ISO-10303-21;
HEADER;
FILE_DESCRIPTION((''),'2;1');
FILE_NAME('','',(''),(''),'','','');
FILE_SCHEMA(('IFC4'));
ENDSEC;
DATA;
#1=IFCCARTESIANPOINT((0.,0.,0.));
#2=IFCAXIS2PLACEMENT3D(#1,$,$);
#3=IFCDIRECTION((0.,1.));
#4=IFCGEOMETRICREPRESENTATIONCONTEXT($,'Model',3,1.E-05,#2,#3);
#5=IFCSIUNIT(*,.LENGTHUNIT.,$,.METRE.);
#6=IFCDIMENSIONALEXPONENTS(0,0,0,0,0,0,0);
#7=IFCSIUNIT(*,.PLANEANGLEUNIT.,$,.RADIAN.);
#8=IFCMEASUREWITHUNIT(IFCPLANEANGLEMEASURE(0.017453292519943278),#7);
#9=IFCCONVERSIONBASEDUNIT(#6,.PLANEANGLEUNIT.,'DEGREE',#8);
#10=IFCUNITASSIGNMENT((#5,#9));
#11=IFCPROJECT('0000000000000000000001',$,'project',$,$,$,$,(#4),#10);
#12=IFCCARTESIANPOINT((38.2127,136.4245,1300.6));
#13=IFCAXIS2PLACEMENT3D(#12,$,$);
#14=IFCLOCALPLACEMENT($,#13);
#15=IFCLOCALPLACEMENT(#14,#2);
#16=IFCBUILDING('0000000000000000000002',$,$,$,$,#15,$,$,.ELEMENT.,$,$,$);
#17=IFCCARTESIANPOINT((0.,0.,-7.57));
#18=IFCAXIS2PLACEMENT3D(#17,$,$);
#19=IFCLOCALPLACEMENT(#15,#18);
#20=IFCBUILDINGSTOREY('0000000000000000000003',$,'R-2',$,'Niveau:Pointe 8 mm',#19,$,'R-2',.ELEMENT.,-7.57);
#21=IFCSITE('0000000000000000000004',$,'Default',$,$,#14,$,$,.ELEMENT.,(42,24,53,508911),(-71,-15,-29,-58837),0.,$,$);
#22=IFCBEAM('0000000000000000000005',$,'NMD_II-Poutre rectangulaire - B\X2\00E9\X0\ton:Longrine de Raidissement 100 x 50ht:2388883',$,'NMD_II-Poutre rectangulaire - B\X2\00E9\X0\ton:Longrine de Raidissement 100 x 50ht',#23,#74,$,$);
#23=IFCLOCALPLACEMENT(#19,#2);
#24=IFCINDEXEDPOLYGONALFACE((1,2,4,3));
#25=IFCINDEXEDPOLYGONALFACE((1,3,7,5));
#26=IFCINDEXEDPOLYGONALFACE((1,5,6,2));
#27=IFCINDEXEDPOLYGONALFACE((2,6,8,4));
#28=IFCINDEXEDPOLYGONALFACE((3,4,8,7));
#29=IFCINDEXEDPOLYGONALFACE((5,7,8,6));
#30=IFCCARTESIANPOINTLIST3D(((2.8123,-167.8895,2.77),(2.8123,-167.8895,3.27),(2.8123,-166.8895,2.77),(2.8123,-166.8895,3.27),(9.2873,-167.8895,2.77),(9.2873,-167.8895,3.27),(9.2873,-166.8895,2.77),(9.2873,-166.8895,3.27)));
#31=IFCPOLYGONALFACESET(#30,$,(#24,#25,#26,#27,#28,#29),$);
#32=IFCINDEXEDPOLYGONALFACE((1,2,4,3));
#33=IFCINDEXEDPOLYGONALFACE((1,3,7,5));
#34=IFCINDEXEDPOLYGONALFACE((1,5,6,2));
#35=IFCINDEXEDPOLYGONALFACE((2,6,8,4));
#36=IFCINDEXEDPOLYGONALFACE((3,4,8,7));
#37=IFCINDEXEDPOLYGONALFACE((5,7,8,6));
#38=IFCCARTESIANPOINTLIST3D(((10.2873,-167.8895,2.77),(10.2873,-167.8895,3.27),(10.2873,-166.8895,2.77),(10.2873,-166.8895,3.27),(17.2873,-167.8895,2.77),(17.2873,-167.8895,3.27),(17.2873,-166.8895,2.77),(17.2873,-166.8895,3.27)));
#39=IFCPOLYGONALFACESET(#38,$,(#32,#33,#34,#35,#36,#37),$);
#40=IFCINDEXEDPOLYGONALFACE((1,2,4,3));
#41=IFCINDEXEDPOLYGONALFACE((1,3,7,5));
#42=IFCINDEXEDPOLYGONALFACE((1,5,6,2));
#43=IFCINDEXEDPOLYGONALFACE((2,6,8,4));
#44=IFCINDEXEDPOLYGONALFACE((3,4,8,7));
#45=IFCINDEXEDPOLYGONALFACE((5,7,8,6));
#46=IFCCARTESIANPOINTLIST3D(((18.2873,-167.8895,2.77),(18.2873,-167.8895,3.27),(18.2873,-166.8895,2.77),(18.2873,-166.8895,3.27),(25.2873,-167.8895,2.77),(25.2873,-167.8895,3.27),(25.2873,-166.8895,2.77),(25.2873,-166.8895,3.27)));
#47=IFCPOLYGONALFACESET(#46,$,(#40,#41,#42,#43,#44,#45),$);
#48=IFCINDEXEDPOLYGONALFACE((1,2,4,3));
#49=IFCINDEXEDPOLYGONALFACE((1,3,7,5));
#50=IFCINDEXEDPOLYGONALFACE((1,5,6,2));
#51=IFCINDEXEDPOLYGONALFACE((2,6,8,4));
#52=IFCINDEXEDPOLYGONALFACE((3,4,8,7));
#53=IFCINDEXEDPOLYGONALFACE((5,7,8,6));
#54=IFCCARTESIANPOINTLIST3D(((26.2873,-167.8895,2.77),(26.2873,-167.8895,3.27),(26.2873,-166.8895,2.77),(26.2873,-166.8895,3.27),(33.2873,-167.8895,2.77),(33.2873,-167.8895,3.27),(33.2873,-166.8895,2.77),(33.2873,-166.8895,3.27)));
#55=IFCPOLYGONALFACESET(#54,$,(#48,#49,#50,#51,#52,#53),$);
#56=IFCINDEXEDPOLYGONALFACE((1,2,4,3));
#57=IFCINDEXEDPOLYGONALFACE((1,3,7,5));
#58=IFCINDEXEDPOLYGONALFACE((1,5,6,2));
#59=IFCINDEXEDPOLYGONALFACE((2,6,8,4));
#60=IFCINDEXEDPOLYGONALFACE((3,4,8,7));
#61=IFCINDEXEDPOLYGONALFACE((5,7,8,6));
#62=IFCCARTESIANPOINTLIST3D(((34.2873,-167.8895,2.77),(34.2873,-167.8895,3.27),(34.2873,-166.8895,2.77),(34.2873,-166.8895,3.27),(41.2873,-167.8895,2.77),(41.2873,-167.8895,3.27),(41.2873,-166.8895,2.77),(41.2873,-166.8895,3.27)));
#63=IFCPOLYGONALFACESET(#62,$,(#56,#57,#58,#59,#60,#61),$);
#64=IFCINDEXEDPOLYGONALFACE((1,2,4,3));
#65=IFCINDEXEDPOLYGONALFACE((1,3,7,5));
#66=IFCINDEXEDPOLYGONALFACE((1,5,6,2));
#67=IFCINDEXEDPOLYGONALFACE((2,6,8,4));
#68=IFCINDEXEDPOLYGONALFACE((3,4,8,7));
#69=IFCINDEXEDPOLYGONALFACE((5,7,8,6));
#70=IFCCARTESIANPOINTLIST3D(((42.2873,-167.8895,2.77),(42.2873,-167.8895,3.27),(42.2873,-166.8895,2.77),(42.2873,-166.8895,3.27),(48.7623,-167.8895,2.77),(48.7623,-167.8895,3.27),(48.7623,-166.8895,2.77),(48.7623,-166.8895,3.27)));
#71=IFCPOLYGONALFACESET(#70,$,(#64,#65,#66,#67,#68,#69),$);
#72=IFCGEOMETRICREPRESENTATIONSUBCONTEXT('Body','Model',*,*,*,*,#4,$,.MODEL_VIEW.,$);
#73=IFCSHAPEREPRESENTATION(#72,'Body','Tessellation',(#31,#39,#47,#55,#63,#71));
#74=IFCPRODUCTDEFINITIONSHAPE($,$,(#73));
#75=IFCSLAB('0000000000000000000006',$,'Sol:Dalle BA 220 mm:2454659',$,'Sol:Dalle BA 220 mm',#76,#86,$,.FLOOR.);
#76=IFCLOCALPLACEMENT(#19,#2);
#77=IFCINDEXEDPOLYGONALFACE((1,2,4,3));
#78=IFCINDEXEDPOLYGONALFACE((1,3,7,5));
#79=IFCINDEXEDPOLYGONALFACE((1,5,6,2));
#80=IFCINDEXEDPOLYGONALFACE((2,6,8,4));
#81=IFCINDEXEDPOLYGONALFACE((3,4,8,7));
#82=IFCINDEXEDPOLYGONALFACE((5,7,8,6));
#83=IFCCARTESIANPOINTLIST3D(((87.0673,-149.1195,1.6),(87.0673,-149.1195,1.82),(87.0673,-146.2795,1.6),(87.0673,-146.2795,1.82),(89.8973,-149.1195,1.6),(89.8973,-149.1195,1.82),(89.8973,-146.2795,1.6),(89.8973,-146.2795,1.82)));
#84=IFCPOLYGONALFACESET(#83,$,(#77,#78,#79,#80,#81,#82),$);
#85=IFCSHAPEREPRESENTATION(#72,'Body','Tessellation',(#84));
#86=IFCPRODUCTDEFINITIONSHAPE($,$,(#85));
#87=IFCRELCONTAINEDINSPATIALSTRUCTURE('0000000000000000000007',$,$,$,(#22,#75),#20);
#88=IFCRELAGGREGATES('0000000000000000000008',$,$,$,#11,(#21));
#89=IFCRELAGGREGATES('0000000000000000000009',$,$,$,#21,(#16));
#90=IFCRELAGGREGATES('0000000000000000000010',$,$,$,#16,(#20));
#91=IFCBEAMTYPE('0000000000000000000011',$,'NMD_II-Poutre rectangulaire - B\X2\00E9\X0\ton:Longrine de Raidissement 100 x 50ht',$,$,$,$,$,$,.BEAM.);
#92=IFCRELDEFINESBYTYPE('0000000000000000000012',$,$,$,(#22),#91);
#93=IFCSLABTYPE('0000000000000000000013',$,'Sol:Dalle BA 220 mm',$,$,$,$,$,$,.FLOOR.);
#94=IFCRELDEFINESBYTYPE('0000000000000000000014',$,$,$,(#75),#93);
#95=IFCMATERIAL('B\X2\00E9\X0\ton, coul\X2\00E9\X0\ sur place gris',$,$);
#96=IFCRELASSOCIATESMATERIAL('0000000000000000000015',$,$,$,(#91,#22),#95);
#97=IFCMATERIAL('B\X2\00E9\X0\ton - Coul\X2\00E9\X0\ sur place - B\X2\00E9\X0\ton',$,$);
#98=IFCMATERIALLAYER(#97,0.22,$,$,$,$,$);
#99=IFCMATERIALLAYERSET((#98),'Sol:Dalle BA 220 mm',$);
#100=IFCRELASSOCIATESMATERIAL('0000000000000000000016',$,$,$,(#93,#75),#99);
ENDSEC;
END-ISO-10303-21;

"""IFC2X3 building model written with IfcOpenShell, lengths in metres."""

from ifc_helpers import new_model, entity, si_unit, converted_unit, direction, frame, frame_2d, origin, place, context, subcontext, project, spatial, rectangle, extrude, source, transform, mapped, material, layer, layer_set, layer_usage, type_object, type_shapes, element, save


model = new_model("IFC2X3")

# Units and contexts
model_context = context("Model", 3, precision=1e-05, world=origin(), true_north=direction((0.0, 1.0)))
body_context = subcontext(model_context, "Body", "Model", "MODEL_VIEW")
ifc_project = project(units=[si_unit("LENGTHUNIT", "METRE"), converted_unit("PLANEANGLEUNIT", "DEGREE", entity("IfcPlaneAngleMeasure", 0.017453292519943278), si_unit("PLANEANGLEUNIT", "RADIAN"), dimensions=[0, 0, 0, 0, 0, 0, 0])], contexts=[model_context])

# Site, building, storey
site_placement = place(None, frame((38.2127, 136.4245, 1300.6)))
site = spatial("IfcSite", under=ifc_project, at=site_placement, Name="Default", CompositionType="ELEMENT", RefLatitude=(42, 24, 53, 508911), RefLongitude=(-71, -15, -29, -58837), RefElevation=0.0)
building_placement = place(site_placement, origin())
building = spatial("IfcBuilding", under=site, at=building_placement, CompositionType="ELEMENT")
storey_placement = place(building_placement, frame((0.0, 0.0, -7.57)))
storey = spatial("IfcBuildingStorey", under=building, at=storey_placement, Name="R-2", ObjectType="Niveau:Pointe 8 mm", LongName="R-2", CompositionType="ELEMENT", Elevation=-7.57)

# Beam
ifc_material_1 = material(Name="Béton, coulé sur place gris")
beam_type_1 = type_object("IfcBeamType", Name="NMD_II-Poutre rectangulaire - Béton:Longrine de Raidissement 100 x 50ht", PredefinedType="BEAM", material=ifc_material_1)
shared_shape_1 = source(origin(), body_context, "Body", "SweptSolid", [
    extrude(rectangle(XDim=0.5, YDim=1.0, at=frame_2d((0.0, 0.0), x_axis=(1.0, 0.0))), frame((9.2873, -167.3895, -4.55), z_axis=(-1.0, 0.0, 0.0), x_axis=(0.0, 0.0, -1.0)), (0.0, 0.0, 1.0), 6.475),
    extrude(rectangle(XDim=0.5, YDim=1.0, at=frame_2d((0.0, 0.0), x_axis=(1.0, 0.0))), frame((17.2873, -167.3895, -4.55), z_axis=(-1.0, 0.0, 0.0), x_axis=(0.0, 0.0, -1.0)), (0.0, 0.0, 1.0), 7.0),
    extrude(rectangle(XDim=0.5, YDim=1.0, at=frame_2d((0.0, 0.0), x_axis=(1.0, 0.0))), frame((25.2873, -167.3895, -4.55), z_axis=(-1.0, 0.0, 0.0), x_axis=(0.0, 0.0, -1.0)), (0.0, 0.0, 1.0), 7.0),
    extrude(rectangle(XDim=0.5, YDim=1.0, at=frame_2d((0.0, 0.0), x_axis=(1.0, 0.0))), frame((33.2873, -167.3895, -4.55), z_axis=(-1.0, 0.0, 0.0), x_axis=(0.0, 0.0, -1.0)), (0.0, 0.0, 1.0), 7.0),
    extrude(rectangle(XDim=0.5, YDim=1.0, at=frame_2d((0.0, 0.0), x_axis=(1.0, 0.0))), frame((41.2873, -167.3895, -4.55), z_axis=(-1.0, 0.0, 0.0), x_axis=(0.0, 0.0, -1.0)), (0.0, 0.0, 1.0), 7.0),
    extrude(rectangle(XDim=0.5, YDim=1.0, at=frame_2d((0.0, 0.0), x_axis=(1.0, 0.0))), frame((48.7623, -167.3895, -4.55), z_axis=(-1.0, 0.0, 0.0), x_axis=(0.0, 0.0, -1.0)), (0.0, 0.0, 1.0), 6.475),
])
type_shapes(beam_type_1, [shared_shape_1])
beam_1_placement = place(storey_placement, frame((0.0, 0.0, 7.57)))
element("IfcBeam", 1, at=beam_1_placement, inside=storey, type_object=beam_type_1, material=ifc_material_1, Name="NMD_II-Poutre rectangulaire - Béton:Longrine de Raidissement 100 x 50ht:2388883", ObjectType="NMD_II-Poutre rectangulaire - Béton:Longrine de Raidissement 100 x 50ht", context=body_context, shape_type="MappedRepresentation", body=[
    mapped(shared_shape_1, transform((0.0, 0.0, 0.0), scale=1.0)),
])

# Slab
ifc_material_2 = material(Name="Béton - Coulé sur place - Béton")
ifc_layer = layer(ifc_material_2, 0.22)
ifc_layer_set = layer_set([ifc_layer], Name="Sol:Dalle BA 220 mm")
ifc_layer_usage = layer_usage(ifc_layer_set, "AXIS3", "POSITIVE", 0.0)
slab_type = type_object("IfcSlabType", Name="Sol:Dalle BA 220 mm", PredefinedType="FLOOR", material=ifc_layer_set)
slab_placement = place(storey_placement, origin())
element("IfcSlab", 2, at=slab_placement, inside=storey, type_object=slab_type, material=ifc_layer_usage, Name="Sol:Dalle BA 220 mm:2454659", ObjectType="Sol:Dalle BA 220 mm", PredefinedType="FLOOR", context=body_context, shape_type="SweptSolid", body=[
    extrude(rectangle(XDim=2.84, YDim=2.83, at=frame_2d((0.0, 0.0), x_axis=(1.0, 0.0))), frame((88.4823, -147.6995, 1.82), z_axis=(0.0, 0.0, -1.0), x_axis=(0.0, 1.0, 0.0)), (0.0, 0.0, 1.0), 0.22),
])

save(model, "model.ifc")
